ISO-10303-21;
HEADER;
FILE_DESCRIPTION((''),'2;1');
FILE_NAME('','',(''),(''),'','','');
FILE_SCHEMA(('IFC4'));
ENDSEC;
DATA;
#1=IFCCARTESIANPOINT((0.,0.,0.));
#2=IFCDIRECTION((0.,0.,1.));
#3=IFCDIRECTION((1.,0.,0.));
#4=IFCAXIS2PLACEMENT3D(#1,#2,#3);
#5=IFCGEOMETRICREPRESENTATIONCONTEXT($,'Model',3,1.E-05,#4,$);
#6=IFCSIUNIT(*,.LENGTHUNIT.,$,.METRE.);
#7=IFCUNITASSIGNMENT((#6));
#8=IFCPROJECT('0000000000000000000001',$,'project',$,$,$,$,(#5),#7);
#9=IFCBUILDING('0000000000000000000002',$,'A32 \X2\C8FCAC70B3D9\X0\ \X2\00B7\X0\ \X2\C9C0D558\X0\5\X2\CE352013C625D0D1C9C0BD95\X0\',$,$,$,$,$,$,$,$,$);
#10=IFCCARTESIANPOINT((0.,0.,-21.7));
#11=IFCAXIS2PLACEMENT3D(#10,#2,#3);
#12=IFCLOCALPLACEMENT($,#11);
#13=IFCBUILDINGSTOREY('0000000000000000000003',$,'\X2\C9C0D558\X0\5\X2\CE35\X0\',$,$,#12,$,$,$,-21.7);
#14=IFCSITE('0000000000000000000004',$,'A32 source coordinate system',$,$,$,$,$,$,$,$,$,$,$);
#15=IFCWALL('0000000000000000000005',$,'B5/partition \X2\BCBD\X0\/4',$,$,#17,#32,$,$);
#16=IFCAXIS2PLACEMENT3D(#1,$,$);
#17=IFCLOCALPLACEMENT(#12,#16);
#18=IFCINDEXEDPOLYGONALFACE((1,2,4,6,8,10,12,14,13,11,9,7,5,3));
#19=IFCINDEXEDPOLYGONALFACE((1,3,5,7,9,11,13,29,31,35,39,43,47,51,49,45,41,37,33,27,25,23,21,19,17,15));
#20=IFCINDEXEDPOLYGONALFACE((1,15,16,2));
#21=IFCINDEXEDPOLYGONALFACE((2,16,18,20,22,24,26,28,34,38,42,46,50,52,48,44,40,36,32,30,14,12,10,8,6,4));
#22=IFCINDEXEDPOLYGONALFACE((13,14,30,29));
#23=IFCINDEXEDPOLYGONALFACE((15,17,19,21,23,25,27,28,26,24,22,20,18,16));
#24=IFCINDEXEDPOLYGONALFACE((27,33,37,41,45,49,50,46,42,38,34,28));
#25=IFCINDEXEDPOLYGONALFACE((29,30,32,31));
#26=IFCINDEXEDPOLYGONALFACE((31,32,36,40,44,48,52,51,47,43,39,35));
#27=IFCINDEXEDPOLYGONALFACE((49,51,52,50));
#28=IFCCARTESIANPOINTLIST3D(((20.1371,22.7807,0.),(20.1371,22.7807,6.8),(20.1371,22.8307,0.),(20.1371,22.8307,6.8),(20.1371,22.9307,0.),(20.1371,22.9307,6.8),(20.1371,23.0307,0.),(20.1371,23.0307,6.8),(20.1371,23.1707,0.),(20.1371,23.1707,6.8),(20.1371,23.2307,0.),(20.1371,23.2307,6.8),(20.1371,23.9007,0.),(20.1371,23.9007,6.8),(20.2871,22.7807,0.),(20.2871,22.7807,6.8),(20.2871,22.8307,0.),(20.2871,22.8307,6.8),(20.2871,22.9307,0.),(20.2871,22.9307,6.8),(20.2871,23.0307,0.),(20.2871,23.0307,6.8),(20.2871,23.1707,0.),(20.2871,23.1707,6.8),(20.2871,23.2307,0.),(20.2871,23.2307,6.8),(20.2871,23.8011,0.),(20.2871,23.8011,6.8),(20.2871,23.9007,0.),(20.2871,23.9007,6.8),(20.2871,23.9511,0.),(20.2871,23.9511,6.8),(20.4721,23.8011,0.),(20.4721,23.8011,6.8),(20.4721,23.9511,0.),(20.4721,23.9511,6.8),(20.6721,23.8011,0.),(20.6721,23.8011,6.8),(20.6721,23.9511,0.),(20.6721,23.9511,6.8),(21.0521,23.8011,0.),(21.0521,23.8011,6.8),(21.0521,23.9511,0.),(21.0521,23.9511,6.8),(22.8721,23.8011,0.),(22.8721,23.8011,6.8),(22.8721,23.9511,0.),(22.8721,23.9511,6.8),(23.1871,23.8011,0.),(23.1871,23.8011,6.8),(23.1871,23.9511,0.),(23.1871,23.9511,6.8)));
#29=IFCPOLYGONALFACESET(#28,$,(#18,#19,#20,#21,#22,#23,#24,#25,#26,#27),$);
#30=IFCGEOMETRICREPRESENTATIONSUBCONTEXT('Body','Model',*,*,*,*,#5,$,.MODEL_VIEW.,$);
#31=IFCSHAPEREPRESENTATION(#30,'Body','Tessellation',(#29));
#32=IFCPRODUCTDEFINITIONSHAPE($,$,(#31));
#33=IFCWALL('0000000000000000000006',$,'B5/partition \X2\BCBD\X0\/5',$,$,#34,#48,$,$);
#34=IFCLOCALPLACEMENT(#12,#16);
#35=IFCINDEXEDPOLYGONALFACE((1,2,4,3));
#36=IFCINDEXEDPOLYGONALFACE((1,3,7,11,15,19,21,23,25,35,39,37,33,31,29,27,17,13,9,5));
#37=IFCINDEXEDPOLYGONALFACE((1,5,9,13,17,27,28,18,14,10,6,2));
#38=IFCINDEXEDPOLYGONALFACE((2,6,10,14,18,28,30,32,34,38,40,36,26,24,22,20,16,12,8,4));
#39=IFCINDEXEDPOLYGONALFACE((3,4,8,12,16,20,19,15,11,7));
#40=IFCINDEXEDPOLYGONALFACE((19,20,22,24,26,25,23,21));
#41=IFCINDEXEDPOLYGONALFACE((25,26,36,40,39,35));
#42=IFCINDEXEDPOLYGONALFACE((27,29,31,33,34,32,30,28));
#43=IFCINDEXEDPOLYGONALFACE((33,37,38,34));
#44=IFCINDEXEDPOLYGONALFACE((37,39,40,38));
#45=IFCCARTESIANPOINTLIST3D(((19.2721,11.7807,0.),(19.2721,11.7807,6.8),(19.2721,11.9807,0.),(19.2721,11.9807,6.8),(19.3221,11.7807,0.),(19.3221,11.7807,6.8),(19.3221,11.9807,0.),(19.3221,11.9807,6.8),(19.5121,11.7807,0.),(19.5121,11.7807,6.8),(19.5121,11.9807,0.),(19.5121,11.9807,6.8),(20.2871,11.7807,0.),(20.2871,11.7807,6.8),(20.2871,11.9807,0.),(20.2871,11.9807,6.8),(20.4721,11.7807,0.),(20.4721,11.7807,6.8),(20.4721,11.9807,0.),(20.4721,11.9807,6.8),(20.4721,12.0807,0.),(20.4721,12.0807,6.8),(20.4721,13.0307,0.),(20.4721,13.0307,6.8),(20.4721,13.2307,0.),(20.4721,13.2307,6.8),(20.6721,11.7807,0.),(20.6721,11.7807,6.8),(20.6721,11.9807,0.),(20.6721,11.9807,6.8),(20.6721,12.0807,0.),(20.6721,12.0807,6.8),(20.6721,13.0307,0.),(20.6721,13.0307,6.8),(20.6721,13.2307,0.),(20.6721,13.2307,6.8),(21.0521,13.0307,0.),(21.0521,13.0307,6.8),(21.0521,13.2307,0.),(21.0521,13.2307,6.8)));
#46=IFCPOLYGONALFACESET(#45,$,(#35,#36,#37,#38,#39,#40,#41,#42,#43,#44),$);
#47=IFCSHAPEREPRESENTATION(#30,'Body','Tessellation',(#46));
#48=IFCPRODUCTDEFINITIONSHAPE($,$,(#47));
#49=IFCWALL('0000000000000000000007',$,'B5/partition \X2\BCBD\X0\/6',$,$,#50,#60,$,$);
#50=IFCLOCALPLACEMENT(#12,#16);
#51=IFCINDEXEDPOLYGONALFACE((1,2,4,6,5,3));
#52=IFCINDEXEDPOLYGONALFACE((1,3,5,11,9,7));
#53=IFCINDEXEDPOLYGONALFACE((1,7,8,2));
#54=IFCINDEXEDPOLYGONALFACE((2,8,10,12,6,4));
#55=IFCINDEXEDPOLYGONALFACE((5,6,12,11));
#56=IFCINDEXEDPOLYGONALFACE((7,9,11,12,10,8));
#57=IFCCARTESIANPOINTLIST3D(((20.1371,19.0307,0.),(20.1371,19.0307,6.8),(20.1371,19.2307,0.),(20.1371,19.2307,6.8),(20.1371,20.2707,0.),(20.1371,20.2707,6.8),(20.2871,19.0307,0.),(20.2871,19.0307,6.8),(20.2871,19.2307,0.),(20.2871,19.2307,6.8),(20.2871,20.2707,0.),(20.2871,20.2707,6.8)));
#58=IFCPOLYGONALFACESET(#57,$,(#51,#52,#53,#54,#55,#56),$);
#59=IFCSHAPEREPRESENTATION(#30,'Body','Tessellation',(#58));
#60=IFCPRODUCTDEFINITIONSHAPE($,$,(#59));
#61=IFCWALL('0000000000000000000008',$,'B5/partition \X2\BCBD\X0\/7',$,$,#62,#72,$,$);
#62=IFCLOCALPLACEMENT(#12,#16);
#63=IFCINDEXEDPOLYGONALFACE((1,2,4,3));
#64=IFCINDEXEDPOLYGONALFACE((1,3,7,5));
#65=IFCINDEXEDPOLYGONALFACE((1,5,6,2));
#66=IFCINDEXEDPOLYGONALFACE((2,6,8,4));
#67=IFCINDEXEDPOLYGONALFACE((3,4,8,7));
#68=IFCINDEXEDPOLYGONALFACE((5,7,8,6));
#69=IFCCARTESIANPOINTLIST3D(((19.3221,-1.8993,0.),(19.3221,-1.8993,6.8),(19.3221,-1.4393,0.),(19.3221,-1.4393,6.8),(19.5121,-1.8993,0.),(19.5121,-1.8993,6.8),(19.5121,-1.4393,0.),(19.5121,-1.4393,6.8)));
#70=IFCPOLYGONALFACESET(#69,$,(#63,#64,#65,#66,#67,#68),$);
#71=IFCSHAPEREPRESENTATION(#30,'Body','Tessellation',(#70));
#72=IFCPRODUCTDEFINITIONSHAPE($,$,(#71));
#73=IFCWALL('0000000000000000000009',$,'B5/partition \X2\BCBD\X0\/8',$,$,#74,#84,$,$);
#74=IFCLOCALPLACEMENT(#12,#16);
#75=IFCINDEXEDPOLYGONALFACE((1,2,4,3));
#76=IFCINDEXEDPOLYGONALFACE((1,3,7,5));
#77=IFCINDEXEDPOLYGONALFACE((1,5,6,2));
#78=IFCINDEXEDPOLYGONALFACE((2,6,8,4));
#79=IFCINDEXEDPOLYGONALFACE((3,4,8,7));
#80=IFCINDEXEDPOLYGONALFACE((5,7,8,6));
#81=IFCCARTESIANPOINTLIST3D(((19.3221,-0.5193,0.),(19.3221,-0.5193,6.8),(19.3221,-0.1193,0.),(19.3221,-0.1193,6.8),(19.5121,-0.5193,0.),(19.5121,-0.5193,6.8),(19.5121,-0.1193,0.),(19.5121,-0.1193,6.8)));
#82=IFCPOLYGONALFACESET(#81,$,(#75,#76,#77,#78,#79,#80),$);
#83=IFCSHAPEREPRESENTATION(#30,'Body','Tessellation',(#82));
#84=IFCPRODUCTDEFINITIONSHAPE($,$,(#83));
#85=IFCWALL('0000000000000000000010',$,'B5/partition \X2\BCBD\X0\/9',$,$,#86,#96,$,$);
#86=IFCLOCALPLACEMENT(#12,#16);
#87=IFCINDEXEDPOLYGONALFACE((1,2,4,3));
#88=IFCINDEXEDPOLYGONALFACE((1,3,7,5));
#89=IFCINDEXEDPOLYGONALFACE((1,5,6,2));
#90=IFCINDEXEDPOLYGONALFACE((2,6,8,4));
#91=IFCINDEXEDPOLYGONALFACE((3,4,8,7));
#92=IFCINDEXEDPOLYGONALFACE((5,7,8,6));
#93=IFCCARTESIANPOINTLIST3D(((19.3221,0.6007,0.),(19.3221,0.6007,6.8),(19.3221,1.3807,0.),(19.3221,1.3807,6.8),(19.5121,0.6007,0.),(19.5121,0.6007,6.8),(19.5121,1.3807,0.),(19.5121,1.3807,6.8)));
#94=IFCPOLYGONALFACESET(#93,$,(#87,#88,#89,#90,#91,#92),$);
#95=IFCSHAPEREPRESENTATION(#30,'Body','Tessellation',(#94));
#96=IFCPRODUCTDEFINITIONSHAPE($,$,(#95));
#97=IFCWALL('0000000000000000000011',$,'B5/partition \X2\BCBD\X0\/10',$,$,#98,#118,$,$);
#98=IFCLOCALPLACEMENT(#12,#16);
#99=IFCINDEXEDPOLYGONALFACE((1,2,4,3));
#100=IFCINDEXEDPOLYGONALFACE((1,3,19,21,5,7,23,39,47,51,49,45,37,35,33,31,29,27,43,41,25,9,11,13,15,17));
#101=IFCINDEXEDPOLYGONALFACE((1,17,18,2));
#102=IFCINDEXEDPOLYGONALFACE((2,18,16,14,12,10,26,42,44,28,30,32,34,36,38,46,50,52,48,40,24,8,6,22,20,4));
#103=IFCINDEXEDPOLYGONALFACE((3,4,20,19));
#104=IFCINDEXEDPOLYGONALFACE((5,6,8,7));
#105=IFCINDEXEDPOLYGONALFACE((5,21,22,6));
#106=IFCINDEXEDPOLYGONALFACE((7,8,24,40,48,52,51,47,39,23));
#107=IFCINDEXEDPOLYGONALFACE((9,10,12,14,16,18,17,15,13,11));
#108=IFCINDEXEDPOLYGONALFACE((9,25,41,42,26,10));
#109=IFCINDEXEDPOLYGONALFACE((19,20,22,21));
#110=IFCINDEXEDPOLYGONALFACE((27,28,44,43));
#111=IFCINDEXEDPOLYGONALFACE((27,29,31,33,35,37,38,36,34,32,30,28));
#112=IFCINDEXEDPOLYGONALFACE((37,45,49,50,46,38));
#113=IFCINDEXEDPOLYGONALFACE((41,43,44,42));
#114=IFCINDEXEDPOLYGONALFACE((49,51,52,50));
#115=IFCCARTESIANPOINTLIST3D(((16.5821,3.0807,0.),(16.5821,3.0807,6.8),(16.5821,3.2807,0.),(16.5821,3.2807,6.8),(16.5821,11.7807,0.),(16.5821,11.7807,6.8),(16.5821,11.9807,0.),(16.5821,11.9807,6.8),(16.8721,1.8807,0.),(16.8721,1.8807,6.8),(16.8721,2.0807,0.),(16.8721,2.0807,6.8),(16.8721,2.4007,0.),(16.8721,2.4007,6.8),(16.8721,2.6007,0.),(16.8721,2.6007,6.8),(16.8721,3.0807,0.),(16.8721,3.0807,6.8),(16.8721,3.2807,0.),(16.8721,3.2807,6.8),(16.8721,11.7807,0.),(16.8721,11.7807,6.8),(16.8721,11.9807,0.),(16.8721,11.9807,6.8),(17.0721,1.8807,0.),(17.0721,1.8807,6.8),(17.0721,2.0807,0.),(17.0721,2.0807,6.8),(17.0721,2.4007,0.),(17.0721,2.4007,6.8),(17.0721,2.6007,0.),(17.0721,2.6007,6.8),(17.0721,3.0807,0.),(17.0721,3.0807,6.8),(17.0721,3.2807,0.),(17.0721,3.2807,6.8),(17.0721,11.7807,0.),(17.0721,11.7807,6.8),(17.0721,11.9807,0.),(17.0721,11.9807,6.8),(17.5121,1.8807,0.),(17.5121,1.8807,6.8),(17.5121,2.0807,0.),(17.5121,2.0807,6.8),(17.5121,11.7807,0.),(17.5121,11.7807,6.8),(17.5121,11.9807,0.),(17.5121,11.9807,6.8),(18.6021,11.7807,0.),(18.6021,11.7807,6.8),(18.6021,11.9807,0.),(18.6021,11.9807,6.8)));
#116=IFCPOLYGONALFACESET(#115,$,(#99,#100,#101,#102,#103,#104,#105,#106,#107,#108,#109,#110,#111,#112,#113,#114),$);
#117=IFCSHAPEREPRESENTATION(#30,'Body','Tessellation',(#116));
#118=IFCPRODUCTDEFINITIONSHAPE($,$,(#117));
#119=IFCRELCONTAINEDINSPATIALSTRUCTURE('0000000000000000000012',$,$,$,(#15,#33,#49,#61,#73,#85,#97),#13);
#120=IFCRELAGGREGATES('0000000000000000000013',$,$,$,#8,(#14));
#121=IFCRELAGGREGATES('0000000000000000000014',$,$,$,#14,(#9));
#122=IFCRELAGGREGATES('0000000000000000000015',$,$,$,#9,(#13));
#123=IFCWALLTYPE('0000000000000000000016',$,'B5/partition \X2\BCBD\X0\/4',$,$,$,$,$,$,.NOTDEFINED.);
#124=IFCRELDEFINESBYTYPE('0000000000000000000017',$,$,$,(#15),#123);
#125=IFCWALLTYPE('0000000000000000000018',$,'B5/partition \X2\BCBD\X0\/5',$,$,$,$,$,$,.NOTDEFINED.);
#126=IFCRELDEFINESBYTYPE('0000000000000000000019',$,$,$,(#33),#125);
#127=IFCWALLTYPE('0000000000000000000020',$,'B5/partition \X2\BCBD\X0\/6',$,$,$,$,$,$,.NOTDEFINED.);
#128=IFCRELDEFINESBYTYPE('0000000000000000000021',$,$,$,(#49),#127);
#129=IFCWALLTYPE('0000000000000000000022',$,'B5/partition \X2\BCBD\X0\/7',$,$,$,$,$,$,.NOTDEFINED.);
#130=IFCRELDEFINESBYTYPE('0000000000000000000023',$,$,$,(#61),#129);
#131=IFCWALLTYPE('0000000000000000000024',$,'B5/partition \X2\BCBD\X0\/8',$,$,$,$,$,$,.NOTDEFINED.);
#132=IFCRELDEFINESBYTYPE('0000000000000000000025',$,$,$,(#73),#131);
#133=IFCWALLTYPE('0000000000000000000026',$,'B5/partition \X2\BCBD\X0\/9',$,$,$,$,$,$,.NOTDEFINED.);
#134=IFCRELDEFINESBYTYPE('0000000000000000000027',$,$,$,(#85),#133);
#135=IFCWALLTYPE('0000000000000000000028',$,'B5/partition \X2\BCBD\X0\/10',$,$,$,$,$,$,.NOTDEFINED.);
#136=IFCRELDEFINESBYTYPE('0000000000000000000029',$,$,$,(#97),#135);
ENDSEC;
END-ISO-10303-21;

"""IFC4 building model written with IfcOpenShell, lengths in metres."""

from ifc_helpers import new_model, si_unit, frame, origin, origin_with_axes, place, context, subcontext, project, spatial, polyline, outline, extrude, source, transform, mapped, type_object, type_shapes, element, save


model = new_model("IFC4")

# Units and contexts
model_context = context("Model", 3, precision=1e-05, world=origin_with_axes())
body_context = subcontext(model_context, "Body", "Model", "MODEL_VIEW")
ifc_project = project(units=[si_unit("LENGTHUNIT", "METRE")], contexts=[model_context])

# Site, building, storey
site = spatial("IfcSite", under=ifc_project, Name="A32 source coordinate system")
building = spatial("IfcBuilding", under=site, Name="A32 주거동 · 지하5층–옥탑지붕")
storey_placement = place(None, frame((0.0, 0.0, -21.7), z_axis=(0.0, 0.0, 1.0), x_axis=(1.0, 0.0, 0.0)))
storey = spatial("IfcBuildingStorey", under=building, at=storey_placement, Name="지하5층", Elevation=-21.7)

# Walls
wall_type_1 = type_object("IfcWallType", Name="B5/partition 벽/4", PredefinedType="NOTDEFINED")
shared_shape_1 = source(origin(), body_context, "Body", "SweptSolid", [
    extrude(outline(polyline([(20.1371, 23.9007), (20.2871, 23.9007), (20.2871, 23.9511), (20.4721, 23.9511), (20.6721, 23.9511), (21.0521, 23.9511), (22.8721, 23.9511), (23.1871, 23.9511), (23.1871, 23.8011), (22.8721, 23.8011), (21.0521, 23.8011), (20.6721, 23.8011), (20.4721, 23.8011), (20.2871, 23.8011), (20.2871, 23.2307), (20.2871, 23.1707), (20.2871, 23.0307), (20.2871, 22.9307), (20.2871, 22.8307), (20.2871, 22.7807), (20.1371, 22.7807), (20.1371, 22.8307), (20.1371, 22.9307), (20.1371, 23.0307), (20.1371, 23.1707), (20.1371, 23.2307), (20.1371, 23.9007)])), origin(), (0.0, 0.0, 1.0), 6.8),
])
type_shapes(wall_type_1, [shared_shape_1])
wall_1_placement = place(storey_placement, origin_with_axes())
element("IfcWall", 1, at=wall_1_placement, inside=storey, type_object=wall_type_1, Name="B5/partition 벽/4", context=body_context, shape_type="MappedRepresentation", body=[
    mapped(shared_shape_1, transform((0.0, 0.0, 0.0), scale=1.0)),
])
wall_type_2 = type_object("IfcWallType", Name="B5/partition 벽/5", PredefinedType="NOTDEFINED")
shared_shape_2 = source(origin(), body_context, "Body", "SweptSolid", [
    extrude(outline(polyline([(19.5121, 11.9807), (20.2871, 11.9807), (20.4721, 11.9807), (20.4721, 12.0807), (20.4721, 13.0307), (20.4721, 13.2307), (20.6721, 13.2307), (21.0521, 13.2307), (21.0521, 13.0307), (20.6721, 13.0307), (20.6721, 12.0807), (20.6721, 11.9807), (20.6721, 11.7807), (20.4721, 11.7807), (20.2871, 11.7807), (19.5121, 11.7807), (19.3221, 11.7807), (19.2721, 11.7807), (19.2721, 11.9807), (19.3221, 11.9807), (19.5121, 11.9807)])), origin(), (0.0, 0.0, 1.0), 6.8),
])
type_shapes(wall_type_2, [shared_shape_2])
wall_2_placement = place(storey_placement, origin_with_axes())
element("IfcWall", 2, at=wall_2_placement, inside=storey, type_object=wall_type_2, Name="B5/partition 벽/5", context=body_context, shape_type="MappedRepresentation", body=[
    mapped(shared_shape_2, transform((0.0, 0.0, 0.0), scale=1.0)),
])
wall_type_3 = type_object("IfcWallType", Name="B5/partition 벽/6", PredefinedType="NOTDEFINED")
shared_shape_3 = source(origin(), body_context, "Body", "SweptSolid", [
    extrude(outline(polyline([(20.1371, 19.2307), (20.1371, 20.2707), (20.2871, 20.2707), (20.2871, 19.2307), (20.2871, 19.0307), (20.1371, 19.0307), (20.1371, 19.2307)])), origin(), (0.0, 0.0, 1.0), 6.8),
])
type_shapes(wall_type_3, [shared_shape_3])
wall_3_placement = place(storey_placement, origin_with_axes())
element("IfcWall", 3, at=wall_3_placement, inside=storey, type_object=wall_type_3, Name="B5/partition 벽/6", context=body_context, shape_type="MappedRepresentation", body=[
    mapped(shared_shape_3, transform((0.0, 0.0, 0.0), scale=1.0)),
])
wall_type_4 = type_object("IfcWallType", Name="B5/partition 벽/7", PredefinedType="NOTDEFINED")
shared_shape_4 = source(origin(), body_context, "Body", "SweptSolid", [
    extrude(outline(polyline([(19.5121, -1.8993), (19.3221, -1.8993), (19.3221, -1.4393), (19.5121, -1.4393), (19.5121, -1.8993)])), origin(), (0.0, 0.0, 1.0), 6.8),
])
type_shapes(wall_type_4, [shared_shape_4])
wall_4_placement = place(storey_placement, origin_with_axes())
element("IfcWall", 4, at=wall_4_placement, inside=storey, type_object=wall_type_4, Name="B5/partition 벽/7", context=body_context, shape_type="MappedRepresentation", body=[
    mapped(shared_shape_4, transform((0.0, 0.0, 0.0), scale=1.0)),
])
wall_type_5 = type_object("IfcWallType", Name="B5/partition 벽/8", PredefinedType="NOTDEFINED")
shared_shape_5 = source(origin(), body_context, "Body", "SweptSolid", [
    extrude(outline(polyline([(19.3221, -0.5193), (19.3221, -0.1193), (19.5121, -0.1193), (19.5121, -0.5193), (19.3221, -0.5193)])), origin(), (0.0, 0.0, 1.0), 6.8),
])
type_shapes(wall_type_5, [shared_shape_5])
wall_5_placement = place(storey_placement, origin_with_axes())
element("IfcWall", 5, at=wall_5_placement, inside=storey, type_object=wall_type_5, Name="B5/partition 벽/8", context=body_context, shape_type="MappedRepresentation", body=[
    mapped(shared_shape_5, transform((0.0, 0.0, 0.0), scale=1.0)),
])
wall_type_6 = type_object("IfcWallType", Name="B5/partition 벽/9", PredefinedType="NOTDEFINED")
shared_shape_6 = source(origin(), body_context, "Body", "SweptSolid", [
    extrude(outline(polyline([(19.3221, 0.6007), (19.3221, 1.3807), (19.5121, 1.3807), (19.5121, 0.6007), (19.3221, 0.6007)])), origin(), (0.0, 0.0, 1.0), 6.8),
])
type_shapes(wall_type_6, [shared_shape_6])
wall_6_placement = place(storey_placement, origin_with_axes())
element("IfcWall", 6, at=wall_6_placement, inside=storey, type_object=wall_type_6, Name="B5/partition 벽/9", context=body_context, shape_type="MappedRepresentation", body=[
    mapped(shared_shape_6, transform((0.0, 0.0, 0.0), scale=1.0)),
])
wall_type_7 = type_object("IfcWallType", Name="B5/partition 벽/10", PredefinedType="NOTDEFINED")
shared_shape_7 = source(origin(), body_context, "Body", "SweptSolid", [
    extrude(outline(polyline([(16.8721, 2.0807), (16.8721, 2.4007), (16.8721, 2.6007), (16.8721, 3.0807), (16.5821, 3.0807), (16.5821, 3.2807), (16.8721, 3.2807), (16.8721, 11.7807), (16.5821, 11.7807), (16.5821, 11.9807), (16.8721, 11.9807), (17.0721, 11.9807), (17.5121, 11.9807), (18.6021, 11.9807), (18.6021, 11.7807), (17.5121, 11.7807), (17.0721, 11.7807), (17.0721, 3.2807), (17.0721, 3.0807), (17.0721, 2.6007), (17.0721, 2.4007), (17.0721, 2.0807), (17.5121, 2.0807), (17.5121, 1.8807), (17.0721, 1.8807), (16.8721, 1.8807), (16.8721, 2.0807)])), origin(), (0.0, 0.0, 1.0), 6.8),
])
type_shapes(wall_type_7, [shared_shape_7])
wall_7_placement = place(storey_placement, origin_with_axes())
element("IfcWall", 7, at=wall_7_placement, inside=storey, type_object=wall_type_7, Name="B5/partition 벽/10", context=body_context, shape_type="MappedRepresentation", body=[
    mapped(shared_shape_7, transform((0.0, 0.0, 0.0), scale=1.0)),
])

save(model, "model.ifc")
